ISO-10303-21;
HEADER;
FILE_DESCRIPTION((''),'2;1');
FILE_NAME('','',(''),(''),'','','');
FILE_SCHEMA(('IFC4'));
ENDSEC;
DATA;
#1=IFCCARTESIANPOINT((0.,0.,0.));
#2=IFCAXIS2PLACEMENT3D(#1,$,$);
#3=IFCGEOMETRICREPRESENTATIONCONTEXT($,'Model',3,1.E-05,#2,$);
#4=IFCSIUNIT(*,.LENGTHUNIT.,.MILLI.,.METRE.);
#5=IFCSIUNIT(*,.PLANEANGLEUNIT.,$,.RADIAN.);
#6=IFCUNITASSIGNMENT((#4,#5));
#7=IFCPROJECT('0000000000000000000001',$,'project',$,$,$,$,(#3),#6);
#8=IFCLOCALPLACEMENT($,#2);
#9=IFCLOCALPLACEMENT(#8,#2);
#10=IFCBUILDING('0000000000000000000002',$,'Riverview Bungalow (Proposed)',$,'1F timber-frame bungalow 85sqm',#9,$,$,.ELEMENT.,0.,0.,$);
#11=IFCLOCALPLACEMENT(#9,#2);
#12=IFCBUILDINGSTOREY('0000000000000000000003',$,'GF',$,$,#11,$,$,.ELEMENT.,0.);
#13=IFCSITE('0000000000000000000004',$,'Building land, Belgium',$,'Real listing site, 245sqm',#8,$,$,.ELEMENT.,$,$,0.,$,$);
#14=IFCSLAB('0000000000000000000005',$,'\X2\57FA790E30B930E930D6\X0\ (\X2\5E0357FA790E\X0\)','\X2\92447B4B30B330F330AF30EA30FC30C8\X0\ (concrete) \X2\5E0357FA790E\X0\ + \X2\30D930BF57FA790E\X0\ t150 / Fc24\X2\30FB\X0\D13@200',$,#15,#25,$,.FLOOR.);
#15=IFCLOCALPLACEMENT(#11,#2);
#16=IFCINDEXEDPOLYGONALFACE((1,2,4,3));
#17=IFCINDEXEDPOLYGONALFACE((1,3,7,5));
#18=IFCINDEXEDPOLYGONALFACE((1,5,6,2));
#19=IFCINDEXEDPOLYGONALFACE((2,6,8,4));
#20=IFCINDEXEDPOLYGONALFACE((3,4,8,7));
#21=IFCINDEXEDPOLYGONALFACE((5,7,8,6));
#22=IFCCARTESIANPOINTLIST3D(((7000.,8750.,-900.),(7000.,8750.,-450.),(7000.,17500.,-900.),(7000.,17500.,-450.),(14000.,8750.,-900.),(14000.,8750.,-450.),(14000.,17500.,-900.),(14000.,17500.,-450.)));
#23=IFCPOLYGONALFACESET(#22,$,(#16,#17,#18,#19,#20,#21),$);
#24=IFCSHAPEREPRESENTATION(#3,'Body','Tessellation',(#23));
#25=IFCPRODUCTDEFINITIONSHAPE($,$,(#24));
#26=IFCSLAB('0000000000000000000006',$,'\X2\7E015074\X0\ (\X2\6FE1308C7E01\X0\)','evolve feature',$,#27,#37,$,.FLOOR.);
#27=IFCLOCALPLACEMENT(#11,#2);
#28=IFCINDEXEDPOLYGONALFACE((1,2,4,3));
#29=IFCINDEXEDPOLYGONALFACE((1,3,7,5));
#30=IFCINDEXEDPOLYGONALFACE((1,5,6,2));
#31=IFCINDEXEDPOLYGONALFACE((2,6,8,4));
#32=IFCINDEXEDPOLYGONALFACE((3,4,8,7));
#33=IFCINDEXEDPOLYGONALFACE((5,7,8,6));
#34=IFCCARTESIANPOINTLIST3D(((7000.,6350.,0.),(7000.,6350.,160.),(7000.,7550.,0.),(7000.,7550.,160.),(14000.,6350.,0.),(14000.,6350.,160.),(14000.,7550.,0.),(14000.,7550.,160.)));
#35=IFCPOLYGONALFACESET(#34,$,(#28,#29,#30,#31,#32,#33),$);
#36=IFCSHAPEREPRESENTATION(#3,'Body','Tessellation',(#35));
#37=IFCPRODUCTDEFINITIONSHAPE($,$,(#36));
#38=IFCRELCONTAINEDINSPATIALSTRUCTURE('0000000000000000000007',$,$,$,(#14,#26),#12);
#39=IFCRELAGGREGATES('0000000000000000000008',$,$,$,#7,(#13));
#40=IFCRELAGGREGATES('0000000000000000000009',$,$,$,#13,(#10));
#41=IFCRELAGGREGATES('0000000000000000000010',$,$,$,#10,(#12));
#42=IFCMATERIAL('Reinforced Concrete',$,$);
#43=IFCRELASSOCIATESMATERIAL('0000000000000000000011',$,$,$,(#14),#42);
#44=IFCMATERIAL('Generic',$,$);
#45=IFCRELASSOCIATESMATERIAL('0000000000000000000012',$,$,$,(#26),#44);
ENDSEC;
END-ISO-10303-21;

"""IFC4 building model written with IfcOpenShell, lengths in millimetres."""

from ifc_helpers import new_model, si_unit, frame, frame_2d, origin, place, context, project, spatial, rectangle, extrude, material, element, save


model = new_model("IFC4")

# Units and contexts
model_context = context("Model", 3, precision=1e-05, world=origin())
ifc_project = project(units=[si_unit("LENGTHUNIT", "METRE", prefix="MILLI"), si_unit("PLANEANGLEUNIT", "RADIAN")], contexts=[model_context])

# Site, building, storey
site_placement = place(None, origin())
site = spatial("IfcSite", under=ifc_project, at=site_placement, Name="Building land, Belgium", ObjectType="Real listing site, 245sqm", CompositionType="ELEMENT", RefElevation=0.0)
building_placement = place(site_placement, origin())
building = spatial("IfcBuilding", under=site, at=building_placement, Name="Riverview Bungalow (Proposed)", ObjectType="1F timber-frame bungalow 85sqm", CompositionType="ELEMENT", ElevationOfRefHeight=0.0, ElevationOfTerrain=0.0)
storey_placement = place(building_placement, origin())
storey = spatial("IfcBuildingStorey", under=building, at=storey_placement, Name="GF", CompositionType="ELEMENT", Elevation=0.0)

# Slabs
ifc_material_1 = material(Name="Reinforced Concrete")
slab_1_placement = place(storey_placement, frame((3500.0, 4375.0, -450.0)))
element("IfcSlab", 1, at=slab_1_placement, inside=storey, material=ifc_material_1, Name="基礎スラブ (布基礎)", Description="鉄筋コンクリート (concrete) 布基礎 + ベタ基礎 t150 / Fc24・D13@200", PredefinedType="FLOOR", context=model_context, shape_type="SweptSolid", body=[
    extrude(rectangle(XDim=7000.0, YDim=8750.0, at=frame_2d((3500.0, 4375.0))), frame((3500.0, 4375.0, -450.0)), (0.0, 0.0, 1.0), 450.0),
])
ifc_material_2 = material(Name="Generic")
slab_2_placement = place(storey_placement, frame((3500.0, 3175.0, 0.0)))
element("IfcSlab", 2, at=slab_2_placement, inside=storey, material=ifc_material_2, Name="縁側 (濡れ縁)", Description="evolve feature", PredefinedType="FLOOR", context=model_context, shape_type="SweptSolid", body=[
    extrude(rectangle(XDim=7000.0, YDim=1200.0, at=frame_2d((3500.0, 600.0))), frame((3500.0, 3175.0, 0.0)), (0.0, 0.0, 1.0), 160.0),
])

save(model, "model.ifc")
